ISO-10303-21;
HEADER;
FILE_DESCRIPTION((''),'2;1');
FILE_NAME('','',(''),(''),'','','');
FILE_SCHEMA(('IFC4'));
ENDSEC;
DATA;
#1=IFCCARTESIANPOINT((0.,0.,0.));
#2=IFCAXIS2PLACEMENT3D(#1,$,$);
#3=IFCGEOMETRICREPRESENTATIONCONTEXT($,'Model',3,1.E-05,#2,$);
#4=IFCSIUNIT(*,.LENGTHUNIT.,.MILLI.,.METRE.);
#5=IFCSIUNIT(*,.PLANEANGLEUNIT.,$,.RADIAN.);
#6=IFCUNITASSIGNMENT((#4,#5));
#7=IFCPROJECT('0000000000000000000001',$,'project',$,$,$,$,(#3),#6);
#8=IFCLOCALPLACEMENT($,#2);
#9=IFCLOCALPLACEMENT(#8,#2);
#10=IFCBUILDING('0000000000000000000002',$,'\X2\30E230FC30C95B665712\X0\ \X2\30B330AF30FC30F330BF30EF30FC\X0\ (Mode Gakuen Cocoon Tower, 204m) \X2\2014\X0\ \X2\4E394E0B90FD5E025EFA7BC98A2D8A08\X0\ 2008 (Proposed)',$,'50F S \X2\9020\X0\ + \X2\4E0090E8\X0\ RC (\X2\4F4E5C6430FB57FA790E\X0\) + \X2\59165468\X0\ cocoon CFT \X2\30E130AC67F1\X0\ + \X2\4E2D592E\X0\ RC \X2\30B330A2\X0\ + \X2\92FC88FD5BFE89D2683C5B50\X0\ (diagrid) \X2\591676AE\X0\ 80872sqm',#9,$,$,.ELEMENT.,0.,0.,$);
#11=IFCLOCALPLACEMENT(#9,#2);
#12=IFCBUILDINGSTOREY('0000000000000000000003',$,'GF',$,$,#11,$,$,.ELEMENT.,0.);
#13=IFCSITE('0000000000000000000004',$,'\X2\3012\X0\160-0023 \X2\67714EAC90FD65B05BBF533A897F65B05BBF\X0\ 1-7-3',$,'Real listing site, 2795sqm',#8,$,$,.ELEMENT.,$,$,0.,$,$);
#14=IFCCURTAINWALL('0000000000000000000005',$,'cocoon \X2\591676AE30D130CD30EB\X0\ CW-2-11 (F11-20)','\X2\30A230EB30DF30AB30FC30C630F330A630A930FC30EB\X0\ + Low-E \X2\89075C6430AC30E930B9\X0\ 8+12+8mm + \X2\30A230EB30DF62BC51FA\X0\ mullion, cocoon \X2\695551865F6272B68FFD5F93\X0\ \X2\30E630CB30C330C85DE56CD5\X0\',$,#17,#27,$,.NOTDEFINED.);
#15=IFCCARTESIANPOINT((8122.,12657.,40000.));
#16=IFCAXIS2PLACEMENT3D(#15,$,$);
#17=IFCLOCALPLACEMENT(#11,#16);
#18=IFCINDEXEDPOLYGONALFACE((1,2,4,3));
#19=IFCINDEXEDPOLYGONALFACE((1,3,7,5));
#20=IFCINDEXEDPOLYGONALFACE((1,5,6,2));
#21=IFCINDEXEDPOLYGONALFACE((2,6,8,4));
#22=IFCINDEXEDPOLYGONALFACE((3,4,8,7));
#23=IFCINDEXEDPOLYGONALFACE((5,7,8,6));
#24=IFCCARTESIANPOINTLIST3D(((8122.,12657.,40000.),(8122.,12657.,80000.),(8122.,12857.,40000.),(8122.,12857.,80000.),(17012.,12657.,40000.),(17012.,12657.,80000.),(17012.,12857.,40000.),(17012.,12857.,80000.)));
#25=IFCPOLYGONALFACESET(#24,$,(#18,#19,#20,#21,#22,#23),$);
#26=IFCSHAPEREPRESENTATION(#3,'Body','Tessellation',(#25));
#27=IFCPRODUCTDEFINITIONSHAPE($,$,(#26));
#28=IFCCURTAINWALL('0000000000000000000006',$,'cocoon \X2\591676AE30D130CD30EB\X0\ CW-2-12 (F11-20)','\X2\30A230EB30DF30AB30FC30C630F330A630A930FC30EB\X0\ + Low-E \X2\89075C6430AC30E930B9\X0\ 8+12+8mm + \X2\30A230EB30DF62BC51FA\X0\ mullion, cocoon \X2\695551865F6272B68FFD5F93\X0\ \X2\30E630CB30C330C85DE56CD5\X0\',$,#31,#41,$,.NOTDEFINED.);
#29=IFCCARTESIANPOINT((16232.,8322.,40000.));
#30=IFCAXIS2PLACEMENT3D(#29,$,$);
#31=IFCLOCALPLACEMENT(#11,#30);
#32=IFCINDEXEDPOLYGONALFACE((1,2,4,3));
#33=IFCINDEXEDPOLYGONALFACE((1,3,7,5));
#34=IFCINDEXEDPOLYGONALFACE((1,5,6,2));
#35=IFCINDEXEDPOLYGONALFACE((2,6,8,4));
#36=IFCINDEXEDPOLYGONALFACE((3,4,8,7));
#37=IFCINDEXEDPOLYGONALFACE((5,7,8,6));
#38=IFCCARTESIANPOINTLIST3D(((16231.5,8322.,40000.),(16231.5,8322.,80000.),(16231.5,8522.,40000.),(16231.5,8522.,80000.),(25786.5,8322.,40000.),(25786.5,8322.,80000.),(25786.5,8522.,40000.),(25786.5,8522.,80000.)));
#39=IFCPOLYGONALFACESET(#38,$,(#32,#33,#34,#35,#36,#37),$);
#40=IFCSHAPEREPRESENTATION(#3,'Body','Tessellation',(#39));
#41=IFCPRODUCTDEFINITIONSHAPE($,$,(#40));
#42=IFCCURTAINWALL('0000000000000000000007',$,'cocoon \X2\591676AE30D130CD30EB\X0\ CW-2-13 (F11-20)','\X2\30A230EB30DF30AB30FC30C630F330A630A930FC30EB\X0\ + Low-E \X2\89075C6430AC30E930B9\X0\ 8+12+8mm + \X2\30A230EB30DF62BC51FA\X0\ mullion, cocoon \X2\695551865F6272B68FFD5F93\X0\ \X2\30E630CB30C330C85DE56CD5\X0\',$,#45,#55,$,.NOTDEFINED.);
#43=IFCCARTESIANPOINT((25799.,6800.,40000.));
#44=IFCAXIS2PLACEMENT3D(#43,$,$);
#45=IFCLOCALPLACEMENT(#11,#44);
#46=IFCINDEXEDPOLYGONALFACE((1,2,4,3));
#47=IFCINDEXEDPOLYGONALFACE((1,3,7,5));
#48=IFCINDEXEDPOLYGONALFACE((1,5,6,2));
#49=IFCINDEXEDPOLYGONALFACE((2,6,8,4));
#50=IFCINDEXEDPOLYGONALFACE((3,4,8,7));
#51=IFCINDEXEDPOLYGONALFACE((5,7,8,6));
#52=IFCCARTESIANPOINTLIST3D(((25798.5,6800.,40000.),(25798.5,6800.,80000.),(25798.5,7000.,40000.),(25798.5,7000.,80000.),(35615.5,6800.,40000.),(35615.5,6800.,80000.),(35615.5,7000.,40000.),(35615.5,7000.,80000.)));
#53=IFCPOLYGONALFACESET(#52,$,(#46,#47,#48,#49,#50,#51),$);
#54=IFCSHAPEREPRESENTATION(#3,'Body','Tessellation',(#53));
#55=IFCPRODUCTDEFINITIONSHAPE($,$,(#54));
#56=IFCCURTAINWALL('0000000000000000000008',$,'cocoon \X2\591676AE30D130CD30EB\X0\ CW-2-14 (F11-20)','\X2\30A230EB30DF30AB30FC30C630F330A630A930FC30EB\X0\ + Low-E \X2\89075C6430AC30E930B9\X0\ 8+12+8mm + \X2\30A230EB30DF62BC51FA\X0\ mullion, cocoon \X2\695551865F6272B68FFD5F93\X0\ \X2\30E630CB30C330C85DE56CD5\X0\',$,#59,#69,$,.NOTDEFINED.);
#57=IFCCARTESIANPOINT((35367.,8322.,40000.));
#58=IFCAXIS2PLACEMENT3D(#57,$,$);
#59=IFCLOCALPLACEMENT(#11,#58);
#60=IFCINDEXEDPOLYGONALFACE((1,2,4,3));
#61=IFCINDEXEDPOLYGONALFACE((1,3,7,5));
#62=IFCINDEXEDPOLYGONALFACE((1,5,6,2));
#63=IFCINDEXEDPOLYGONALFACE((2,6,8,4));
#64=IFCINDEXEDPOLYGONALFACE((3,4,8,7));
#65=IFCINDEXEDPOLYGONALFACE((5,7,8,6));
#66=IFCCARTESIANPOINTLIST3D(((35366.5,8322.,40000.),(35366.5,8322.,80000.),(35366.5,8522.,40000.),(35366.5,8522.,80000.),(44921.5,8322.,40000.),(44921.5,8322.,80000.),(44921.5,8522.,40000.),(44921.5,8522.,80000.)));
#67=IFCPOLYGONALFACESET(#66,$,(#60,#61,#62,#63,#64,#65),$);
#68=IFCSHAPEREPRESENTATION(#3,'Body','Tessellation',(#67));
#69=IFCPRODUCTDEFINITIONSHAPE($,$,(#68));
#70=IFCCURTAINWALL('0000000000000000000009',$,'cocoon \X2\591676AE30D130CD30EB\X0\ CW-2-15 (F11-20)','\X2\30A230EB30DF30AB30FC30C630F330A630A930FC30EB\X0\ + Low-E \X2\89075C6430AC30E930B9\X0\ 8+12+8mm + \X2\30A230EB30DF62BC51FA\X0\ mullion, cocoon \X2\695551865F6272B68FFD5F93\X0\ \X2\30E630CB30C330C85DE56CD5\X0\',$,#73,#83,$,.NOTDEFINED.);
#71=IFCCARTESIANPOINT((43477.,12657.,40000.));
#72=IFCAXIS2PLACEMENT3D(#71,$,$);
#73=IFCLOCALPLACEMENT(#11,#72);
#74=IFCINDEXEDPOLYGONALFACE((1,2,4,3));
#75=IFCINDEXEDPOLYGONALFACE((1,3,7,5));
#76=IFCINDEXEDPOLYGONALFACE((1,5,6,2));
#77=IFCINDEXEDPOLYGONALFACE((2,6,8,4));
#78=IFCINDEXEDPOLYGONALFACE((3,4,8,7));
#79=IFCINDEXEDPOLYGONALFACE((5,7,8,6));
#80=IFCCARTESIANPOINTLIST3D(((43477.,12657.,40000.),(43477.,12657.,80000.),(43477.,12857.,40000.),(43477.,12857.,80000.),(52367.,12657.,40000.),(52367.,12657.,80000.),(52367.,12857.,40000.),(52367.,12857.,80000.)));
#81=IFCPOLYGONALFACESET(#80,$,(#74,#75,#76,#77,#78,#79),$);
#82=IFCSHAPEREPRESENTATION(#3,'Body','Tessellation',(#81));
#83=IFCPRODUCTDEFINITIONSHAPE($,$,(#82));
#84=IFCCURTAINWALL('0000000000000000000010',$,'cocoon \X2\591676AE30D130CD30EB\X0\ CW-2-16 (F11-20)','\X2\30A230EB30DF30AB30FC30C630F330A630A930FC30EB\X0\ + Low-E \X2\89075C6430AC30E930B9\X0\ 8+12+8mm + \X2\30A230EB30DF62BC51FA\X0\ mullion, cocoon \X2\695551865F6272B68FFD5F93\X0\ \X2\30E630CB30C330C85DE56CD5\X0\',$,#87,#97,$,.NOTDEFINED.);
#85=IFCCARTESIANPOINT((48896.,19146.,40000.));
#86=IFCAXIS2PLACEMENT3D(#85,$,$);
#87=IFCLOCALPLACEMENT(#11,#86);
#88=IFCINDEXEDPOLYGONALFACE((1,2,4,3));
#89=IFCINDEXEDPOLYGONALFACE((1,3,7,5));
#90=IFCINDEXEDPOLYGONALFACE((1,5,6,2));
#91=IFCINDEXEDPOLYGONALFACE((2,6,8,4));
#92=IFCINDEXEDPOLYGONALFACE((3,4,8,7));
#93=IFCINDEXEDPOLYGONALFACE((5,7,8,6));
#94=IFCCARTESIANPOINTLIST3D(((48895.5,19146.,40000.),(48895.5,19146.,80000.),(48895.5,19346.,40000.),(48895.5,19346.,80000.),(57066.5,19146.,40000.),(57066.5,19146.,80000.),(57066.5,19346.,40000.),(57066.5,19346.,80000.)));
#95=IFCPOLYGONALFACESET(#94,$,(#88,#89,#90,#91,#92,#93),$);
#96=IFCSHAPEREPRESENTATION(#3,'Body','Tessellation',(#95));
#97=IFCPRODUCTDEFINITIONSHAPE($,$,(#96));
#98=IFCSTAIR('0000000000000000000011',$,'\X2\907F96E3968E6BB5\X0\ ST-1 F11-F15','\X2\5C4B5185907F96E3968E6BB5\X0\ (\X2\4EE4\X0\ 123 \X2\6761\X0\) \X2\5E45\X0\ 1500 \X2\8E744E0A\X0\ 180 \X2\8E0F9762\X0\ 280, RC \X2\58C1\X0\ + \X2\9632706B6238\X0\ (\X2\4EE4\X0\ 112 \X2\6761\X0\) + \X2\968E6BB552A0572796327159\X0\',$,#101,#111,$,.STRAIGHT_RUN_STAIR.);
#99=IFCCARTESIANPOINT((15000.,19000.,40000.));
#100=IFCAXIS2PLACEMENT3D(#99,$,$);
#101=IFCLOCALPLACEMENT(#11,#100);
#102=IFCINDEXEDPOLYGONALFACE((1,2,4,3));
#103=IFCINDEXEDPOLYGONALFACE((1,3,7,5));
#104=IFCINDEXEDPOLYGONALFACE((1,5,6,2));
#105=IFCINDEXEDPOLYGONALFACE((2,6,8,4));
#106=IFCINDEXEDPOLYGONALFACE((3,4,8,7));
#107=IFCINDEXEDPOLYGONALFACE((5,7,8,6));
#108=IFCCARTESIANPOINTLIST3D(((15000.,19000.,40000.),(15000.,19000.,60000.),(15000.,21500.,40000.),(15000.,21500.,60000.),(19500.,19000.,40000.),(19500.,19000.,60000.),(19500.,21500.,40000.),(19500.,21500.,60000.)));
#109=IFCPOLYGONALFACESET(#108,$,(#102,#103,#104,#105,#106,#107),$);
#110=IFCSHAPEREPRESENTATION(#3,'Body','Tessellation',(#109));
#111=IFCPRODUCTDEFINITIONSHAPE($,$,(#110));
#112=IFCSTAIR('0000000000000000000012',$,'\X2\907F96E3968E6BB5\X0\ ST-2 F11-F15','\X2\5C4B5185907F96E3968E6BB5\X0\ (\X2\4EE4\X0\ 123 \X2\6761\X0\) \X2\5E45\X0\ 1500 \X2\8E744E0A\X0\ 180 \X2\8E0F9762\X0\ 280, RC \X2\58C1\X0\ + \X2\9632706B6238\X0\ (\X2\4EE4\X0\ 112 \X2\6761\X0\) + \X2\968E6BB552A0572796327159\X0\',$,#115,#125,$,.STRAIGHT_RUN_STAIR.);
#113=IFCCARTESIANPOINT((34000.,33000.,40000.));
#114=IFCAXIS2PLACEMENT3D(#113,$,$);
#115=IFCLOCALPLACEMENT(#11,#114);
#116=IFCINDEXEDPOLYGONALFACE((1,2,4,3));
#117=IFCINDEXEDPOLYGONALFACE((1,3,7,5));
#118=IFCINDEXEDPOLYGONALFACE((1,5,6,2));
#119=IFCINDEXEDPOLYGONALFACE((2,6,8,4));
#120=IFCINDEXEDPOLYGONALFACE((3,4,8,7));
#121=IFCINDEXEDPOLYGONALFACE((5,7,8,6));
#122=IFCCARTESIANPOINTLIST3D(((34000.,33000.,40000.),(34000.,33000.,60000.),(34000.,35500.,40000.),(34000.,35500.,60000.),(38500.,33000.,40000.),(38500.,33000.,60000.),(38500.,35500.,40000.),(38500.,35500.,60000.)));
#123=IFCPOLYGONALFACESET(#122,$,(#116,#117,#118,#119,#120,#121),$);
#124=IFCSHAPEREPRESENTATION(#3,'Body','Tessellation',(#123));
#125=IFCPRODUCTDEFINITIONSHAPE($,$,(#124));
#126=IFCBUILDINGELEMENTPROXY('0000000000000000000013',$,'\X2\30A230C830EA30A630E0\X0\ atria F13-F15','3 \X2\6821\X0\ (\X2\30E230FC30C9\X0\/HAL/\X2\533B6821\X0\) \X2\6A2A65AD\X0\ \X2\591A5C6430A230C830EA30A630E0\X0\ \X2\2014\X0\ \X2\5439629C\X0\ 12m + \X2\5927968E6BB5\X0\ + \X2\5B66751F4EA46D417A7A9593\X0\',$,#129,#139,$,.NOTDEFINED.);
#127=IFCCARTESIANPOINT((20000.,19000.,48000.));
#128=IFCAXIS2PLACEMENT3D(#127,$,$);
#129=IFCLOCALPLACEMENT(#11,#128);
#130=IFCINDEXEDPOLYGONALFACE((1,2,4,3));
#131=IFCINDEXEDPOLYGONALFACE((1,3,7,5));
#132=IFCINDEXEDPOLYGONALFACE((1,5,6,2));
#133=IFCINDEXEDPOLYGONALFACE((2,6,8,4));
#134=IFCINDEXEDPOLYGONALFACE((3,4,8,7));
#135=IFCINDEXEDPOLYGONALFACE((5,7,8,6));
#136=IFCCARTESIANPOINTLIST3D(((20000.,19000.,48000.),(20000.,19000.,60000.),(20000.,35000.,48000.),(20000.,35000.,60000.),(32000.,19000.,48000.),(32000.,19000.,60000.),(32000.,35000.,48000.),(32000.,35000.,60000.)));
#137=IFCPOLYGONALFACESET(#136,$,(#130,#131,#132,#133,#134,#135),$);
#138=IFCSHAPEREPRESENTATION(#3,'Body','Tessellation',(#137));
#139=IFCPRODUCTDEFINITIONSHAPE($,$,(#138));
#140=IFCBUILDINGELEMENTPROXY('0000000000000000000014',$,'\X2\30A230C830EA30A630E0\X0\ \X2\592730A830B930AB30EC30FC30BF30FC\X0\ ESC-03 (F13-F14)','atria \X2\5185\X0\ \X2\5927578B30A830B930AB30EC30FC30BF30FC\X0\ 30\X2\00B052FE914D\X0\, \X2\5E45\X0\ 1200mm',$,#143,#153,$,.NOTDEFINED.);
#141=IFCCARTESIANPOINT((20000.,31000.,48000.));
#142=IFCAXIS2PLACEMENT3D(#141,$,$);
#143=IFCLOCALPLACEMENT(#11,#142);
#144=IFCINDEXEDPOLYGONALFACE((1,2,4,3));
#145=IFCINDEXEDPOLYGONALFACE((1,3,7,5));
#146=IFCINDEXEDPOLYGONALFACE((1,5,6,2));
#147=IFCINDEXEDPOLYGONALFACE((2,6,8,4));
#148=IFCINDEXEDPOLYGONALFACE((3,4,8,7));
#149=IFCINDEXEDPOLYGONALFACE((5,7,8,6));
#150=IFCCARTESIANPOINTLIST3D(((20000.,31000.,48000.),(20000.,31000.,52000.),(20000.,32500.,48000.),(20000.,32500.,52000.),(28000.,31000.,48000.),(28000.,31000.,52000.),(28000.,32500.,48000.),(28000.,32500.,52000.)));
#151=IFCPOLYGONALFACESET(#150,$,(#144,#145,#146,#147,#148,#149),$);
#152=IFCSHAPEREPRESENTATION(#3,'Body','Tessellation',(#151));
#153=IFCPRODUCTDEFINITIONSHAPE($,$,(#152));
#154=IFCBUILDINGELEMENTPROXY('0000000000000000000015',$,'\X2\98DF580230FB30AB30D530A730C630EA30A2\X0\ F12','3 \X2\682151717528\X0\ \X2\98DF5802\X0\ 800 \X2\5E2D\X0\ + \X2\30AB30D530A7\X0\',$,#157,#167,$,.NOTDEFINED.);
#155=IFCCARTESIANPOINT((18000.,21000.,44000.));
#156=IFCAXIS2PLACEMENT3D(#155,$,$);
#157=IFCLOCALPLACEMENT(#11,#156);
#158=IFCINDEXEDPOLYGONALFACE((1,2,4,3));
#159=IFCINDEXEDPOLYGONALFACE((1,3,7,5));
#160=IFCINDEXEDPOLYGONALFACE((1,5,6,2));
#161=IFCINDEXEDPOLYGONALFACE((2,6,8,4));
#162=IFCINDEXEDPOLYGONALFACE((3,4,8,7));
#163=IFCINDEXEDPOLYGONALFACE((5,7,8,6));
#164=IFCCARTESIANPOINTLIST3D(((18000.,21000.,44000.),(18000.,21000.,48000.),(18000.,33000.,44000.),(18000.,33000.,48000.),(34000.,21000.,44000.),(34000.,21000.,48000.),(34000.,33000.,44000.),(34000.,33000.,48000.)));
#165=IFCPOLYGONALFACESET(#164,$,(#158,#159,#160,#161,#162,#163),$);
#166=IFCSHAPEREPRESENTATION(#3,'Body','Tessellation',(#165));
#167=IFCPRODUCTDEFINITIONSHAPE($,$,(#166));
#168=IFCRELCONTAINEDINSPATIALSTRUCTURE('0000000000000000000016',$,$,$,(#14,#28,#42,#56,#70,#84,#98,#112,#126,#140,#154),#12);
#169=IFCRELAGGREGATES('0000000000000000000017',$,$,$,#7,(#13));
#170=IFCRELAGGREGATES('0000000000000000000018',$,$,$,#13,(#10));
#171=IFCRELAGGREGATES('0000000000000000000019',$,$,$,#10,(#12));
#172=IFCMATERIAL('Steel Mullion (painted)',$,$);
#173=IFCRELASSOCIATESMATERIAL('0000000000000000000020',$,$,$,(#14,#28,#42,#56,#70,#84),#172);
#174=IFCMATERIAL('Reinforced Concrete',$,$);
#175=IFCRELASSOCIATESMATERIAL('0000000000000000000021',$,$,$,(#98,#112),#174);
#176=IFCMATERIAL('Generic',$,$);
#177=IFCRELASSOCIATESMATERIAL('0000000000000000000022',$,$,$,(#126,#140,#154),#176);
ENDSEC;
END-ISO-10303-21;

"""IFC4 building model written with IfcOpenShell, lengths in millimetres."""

from ifc_helpers import new_model, si_unit, frame, frame_2d, origin, place, context, project, spatial, rectangle, extrude, material, element, save


model = new_model("IFC4")

# Units and contexts
model_context = context("Model", 3, precision=1e-05, world=origin())
ifc_project = project(units=[si_unit("LENGTHUNIT", "METRE", prefix="MILLI"), si_unit("PLANEANGLEUNIT", "RADIAN")], contexts=[model_context])

# Site, building, storey
site_placement = place(None, origin())
site = spatial("IfcSite", under=ifc_project, at=site_placement, Name="〒160-0023 東京都新宿区西新宿 1-7-3", ObjectType="Real listing site, 2795sqm", CompositionType="ELEMENT", RefElevation=0.0)
building_placement = place(site_placement, origin())
building = spatial("IfcBuilding", under=site, at=building_placement, Name="モード学園 コクーンタワー (Mode Gakuen Cocoon Tower, 204m) — 丹下都市建築設計 2008 (Proposed)", ObjectType="50F S 造 + 一部 RC (低層・基礎) + 外周 cocoon CFT メガ柱 + 中央 RC コア + 鋼製対角格子 (diagrid) 外皮 80872sqm", CompositionType="ELEMENT", ElevationOfRefHeight=0.0, ElevationOfTerrain=0.0)
storey_placement = place(building_placement, origin())
storey = spatial("IfcBuildingStorey", under=building, at=storey_placement, Name="GF", CompositionType="ELEMENT", Elevation=0.0)

# Shared definitions
ifc_material_1 = material(Name="Generic")

# Curtain walls
ifc_material_2 = material(Name="Steel Mullion (painted)")
curtain_wall_1_placement = place(storey_placement, frame((8122.0, 12657.0, 40000.0)))
element("IfcCurtainWall", 1, at=curtain_wall_1_placement, inside=storey, material=ifc_material_2, Name="cocoon 外皮パネル CW-2-11 (F11-20)", Description="アルミカーテンウォール + Low-E 複層ガラス 8+12+8mm + アルミ押出 mullion, cocoon 楕円形状追従 ユニット工法", PredefinedType="NOTDEFINED", context=model_context, shape_type="SweptSolid", body=[
    extrude(rectangle(XDim=8890.0, YDim=200.0, at=frame_2d((4445.0, 100.0))), frame((8122.0, 12657.0, 40000.0)), (0.0, 0.0, 1.0), 40000.0),
])
curtain_wall_2_placement = place(storey_placement, frame((16232.0, 8322.0, 40000.0)))
element("IfcCurtainWall", 2, at=curtain_wall_2_placement, inside=storey, material=ifc_material_2, Name="cocoon 外皮パネル CW-2-12 (F11-20)", Description="アルミカーテンウォール + Low-E 複層ガラス 8+12+8mm + アルミ押出 mullion, cocoon 楕円形状追従 ユニット工法", PredefinedType="NOTDEFINED", context=model_context, shape_type="SweptSolid", body=[
    extrude(rectangle(XDim=9555.0, YDim=200.0, at=frame_2d((4777.0, 100.0))), frame((16232.0, 8322.0, 40000.0)), (0.0, 0.0, 1.0), 40000.0),
])
curtain_wall_3_placement = place(storey_placement, frame((25799.0, 6800.0, 40000.0)))
element("IfcCurtainWall", 3, at=curtain_wall_3_placement, inside=storey, material=ifc_material_2, Name="cocoon 外皮パネル CW-2-13 (F11-20)", Description="アルミカーテンウォール + Low-E 複層ガラス 8+12+8mm + アルミ押出 mullion, cocoon 楕円形状追従 ユニット工法", PredefinedType="NOTDEFINED", context=model_context, shape_type="SweptSolid", body=[
    extrude(rectangle(XDim=9817.0, YDim=200.0, at=frame_2d((4908.0, 100.0))), frame((25799.0, 6800.0, 40000.0)), (0.0, 0.0, 1.0), 40000.0),
])
curtain_wall_4_placement = place(storey_placement, frame((35367.0, 8322.0, 40000.0)))
element("IfcCurtainWall", 4, at=curtain_wall_4_placement, inside=storey, material=ifc_material_2, Name="cocoon 外皮パネル CW-2-14 (F11-20)", Description="アルミカーテンウォール + Low-E 複層ガラス 8+12+8mm + アルミ押出 mullion, cocoon 楕円形状追従 ユニット工法", PredefinedType="NOTDEFINED", context=model_context, shape_type="SweptSolid", body=[
    extrude(rectangle(XDim=9555.0, YDim=200.0, at=frame_2d((4777.0, 100.0))), frame((35367.0, 8322.0, 40000.0)), (0.0, 0.0, 1.0), 40000.0),
])
curtain_wall_5_placement = place(storey_placement, frame((43477.0, 12657.0, 40000.0)))
element("IfcCurtainWall", 5, at=curtain_wall_5_placement, inside=storey, material=ifc_material_2, Name="cocoon 外皮パネル CW-2-15 (F11-20)", Description="アルミカーテンウォール + Low-E 複層ガラス 8+12+8mm + アルミ押出 mullion, cocoon 楕円形状追従 ユニット工法", PredefinedType="NOTDEFINED", context=model_context, shape_type="SweptSolid", body=[
    extrude(rectangle(XDim=8890.0, YDim=200.0, at=frame_2d((4445.0, 100.0))), frame((43477.0, 12657.0, 40000.0)), (0.0, 0.0, 1.0), 40000.0),
])
curtain_wall_6_placement = place(storey_placement, frame((48896.0, 19146.0, 40000.0)))
element("IfcCurtainWall", 6, at=curtain_wall_6_placement, inside=storey, material=ifc_material_2, Name="cocoon 外皮パネル CW-2-16 (F11-20)", Description="アルミカーテンウォール + Low-E 複層ガラス 8+12+8mm + アルミ押出 mullion, cocoon 楕円形状追従 ユニット工法", PredefinedType="NOTDEFINED", context=model_context, shape_type="SweptSolid", body=[
    extrude(rectangle(XDim=8171.0, YDim=200.0, at=frame_2d((4085.0, 100.0))), frame((48896.0, 19146.0, 40000.0)), (0.0, 0.0, 1.0), 40000.0),
])

# Stairs
ifc_material_3 = material(Name="Reinforced Concrete")
stair_1_placement = place(storey_placement, frame((15000.0, 19000.0, 40000.0)))
element("IfcStair", 7, at=stair_1_placement, inside=storey, material=ifc_material_3, Name="避難階段 ST-1 F11-F15", Description="屋内避難階段 (令 123 条) 幅 1500 蹴上 180 踏面 280, RC 壁 + 防火戸 (令 112 条) + 階段加圧防煙", PredefinedType="STRAIGHT_RUN_STAIR", context=model_context, shape_type="SweptSolid", body=[
    extrude(rectangle(XDim=4500.0, YDim=2500.0, at=frame_2d((2250.0, 1250.0))), frame((15000.0, 19000.0, 40000.0)), (0.0, 0.0, 1.0), 20000.0),
])
stair_2_placement = place(storey_placement, frame((34000.0, 33000.0, 40000.0)))
element("IfcStair", 8, at=stair_2_placement, inside=storey, material=ifc_material_3, Name="避難階段 ST-2 F11-F15", Description="屋内避難階段 (令 123 条) 幅 1500 蹴上 180 踏面 280, RC 壁 + 防火戸 (令 112 条) + 階段加圧防煙", PredefinedType="STRAIGHT_RUN_STAIR", context=model_context, shape_type="SweptSolid", body=[
    extrude(rectangle(XDim=4500.0, YDim=2500.0, at=frame_2d((2250.0, 1250.0))), frame((34000.0, 33000.0, 40000.0)), (0.0, 0.0, 1.0), 20000.0),
])

# Building element proxies
proxy_1_placement = place(storey_placement, frame((20000.0, 19000.0, 48000.0)))
element("IfcBuildingElementProxy", 9, at=proxy_1_placement, inside=storey, material=ifc_material_1, Name="アトリウム atria F13-F15", Description="3 校 (モード/HAL/医校) 横断 多層アトリウム — 吹抜 12m + 大階段 + 学生交流空間", PredefinedType="NOTDEFINED", context=model_context, shape_type="SweptSolid", body=[
    extrude(rectangle(XDim=12000.0, YDim=16000.0, at=frame_2d((6000.0, 8000.0))), frame((20000.0, 19000.0, 48000.0)), (0.0, 0.0, 1.0), 12000.0),
])
proxy_2_placement = place(storey_placement, frame((20000.0, 31000.0, 48000.0)))
element("IfcBuildingElementProxy", 10, at=proxy_2_placement, inside=storey, material=ifc_material_1, Name="アトリウム 大エスカレーター ESC-03 (F13-F14)", Description="atria 内 大型エスカレーター 30°勾配, 幅 1200mm", PredefinedType="NOTDEFINED", context=model_context, shape_type="SweptSolid", body=[
    extrude(rectangle(XDim=8000.0, YDim=1500.0, at=frame_2d((4000.0, 750.0))), frame((20000.0, 31000.0, 48000.0)), (0.0, 0.0, 1.0), 4000.0),
])
proxy_3_placement = place(storey_placement, frame((18000.0, 21000.0, 44000.0)))
element("IfcBuildingElementProxy", 11, at=proxy_3_placement, inside=storey, material=ifc_material_1, Name="食堂・カフェテリア F12", Description="3 校共用 食堂 800 席 + カフェ", PredefinedType="NOTDEFINED", context=model_context, shape_type="SweptSolid", body=[
    extrude(rectangle(XDim=16000.0, YDim=12000.0, at=frame_2d((8000.0, 6000.0))), frame((18000.0, 21000.0, 44000.0)), (0.0, 0.0, 1.0), 4000.0),
])

save(model, "model.ifc")
